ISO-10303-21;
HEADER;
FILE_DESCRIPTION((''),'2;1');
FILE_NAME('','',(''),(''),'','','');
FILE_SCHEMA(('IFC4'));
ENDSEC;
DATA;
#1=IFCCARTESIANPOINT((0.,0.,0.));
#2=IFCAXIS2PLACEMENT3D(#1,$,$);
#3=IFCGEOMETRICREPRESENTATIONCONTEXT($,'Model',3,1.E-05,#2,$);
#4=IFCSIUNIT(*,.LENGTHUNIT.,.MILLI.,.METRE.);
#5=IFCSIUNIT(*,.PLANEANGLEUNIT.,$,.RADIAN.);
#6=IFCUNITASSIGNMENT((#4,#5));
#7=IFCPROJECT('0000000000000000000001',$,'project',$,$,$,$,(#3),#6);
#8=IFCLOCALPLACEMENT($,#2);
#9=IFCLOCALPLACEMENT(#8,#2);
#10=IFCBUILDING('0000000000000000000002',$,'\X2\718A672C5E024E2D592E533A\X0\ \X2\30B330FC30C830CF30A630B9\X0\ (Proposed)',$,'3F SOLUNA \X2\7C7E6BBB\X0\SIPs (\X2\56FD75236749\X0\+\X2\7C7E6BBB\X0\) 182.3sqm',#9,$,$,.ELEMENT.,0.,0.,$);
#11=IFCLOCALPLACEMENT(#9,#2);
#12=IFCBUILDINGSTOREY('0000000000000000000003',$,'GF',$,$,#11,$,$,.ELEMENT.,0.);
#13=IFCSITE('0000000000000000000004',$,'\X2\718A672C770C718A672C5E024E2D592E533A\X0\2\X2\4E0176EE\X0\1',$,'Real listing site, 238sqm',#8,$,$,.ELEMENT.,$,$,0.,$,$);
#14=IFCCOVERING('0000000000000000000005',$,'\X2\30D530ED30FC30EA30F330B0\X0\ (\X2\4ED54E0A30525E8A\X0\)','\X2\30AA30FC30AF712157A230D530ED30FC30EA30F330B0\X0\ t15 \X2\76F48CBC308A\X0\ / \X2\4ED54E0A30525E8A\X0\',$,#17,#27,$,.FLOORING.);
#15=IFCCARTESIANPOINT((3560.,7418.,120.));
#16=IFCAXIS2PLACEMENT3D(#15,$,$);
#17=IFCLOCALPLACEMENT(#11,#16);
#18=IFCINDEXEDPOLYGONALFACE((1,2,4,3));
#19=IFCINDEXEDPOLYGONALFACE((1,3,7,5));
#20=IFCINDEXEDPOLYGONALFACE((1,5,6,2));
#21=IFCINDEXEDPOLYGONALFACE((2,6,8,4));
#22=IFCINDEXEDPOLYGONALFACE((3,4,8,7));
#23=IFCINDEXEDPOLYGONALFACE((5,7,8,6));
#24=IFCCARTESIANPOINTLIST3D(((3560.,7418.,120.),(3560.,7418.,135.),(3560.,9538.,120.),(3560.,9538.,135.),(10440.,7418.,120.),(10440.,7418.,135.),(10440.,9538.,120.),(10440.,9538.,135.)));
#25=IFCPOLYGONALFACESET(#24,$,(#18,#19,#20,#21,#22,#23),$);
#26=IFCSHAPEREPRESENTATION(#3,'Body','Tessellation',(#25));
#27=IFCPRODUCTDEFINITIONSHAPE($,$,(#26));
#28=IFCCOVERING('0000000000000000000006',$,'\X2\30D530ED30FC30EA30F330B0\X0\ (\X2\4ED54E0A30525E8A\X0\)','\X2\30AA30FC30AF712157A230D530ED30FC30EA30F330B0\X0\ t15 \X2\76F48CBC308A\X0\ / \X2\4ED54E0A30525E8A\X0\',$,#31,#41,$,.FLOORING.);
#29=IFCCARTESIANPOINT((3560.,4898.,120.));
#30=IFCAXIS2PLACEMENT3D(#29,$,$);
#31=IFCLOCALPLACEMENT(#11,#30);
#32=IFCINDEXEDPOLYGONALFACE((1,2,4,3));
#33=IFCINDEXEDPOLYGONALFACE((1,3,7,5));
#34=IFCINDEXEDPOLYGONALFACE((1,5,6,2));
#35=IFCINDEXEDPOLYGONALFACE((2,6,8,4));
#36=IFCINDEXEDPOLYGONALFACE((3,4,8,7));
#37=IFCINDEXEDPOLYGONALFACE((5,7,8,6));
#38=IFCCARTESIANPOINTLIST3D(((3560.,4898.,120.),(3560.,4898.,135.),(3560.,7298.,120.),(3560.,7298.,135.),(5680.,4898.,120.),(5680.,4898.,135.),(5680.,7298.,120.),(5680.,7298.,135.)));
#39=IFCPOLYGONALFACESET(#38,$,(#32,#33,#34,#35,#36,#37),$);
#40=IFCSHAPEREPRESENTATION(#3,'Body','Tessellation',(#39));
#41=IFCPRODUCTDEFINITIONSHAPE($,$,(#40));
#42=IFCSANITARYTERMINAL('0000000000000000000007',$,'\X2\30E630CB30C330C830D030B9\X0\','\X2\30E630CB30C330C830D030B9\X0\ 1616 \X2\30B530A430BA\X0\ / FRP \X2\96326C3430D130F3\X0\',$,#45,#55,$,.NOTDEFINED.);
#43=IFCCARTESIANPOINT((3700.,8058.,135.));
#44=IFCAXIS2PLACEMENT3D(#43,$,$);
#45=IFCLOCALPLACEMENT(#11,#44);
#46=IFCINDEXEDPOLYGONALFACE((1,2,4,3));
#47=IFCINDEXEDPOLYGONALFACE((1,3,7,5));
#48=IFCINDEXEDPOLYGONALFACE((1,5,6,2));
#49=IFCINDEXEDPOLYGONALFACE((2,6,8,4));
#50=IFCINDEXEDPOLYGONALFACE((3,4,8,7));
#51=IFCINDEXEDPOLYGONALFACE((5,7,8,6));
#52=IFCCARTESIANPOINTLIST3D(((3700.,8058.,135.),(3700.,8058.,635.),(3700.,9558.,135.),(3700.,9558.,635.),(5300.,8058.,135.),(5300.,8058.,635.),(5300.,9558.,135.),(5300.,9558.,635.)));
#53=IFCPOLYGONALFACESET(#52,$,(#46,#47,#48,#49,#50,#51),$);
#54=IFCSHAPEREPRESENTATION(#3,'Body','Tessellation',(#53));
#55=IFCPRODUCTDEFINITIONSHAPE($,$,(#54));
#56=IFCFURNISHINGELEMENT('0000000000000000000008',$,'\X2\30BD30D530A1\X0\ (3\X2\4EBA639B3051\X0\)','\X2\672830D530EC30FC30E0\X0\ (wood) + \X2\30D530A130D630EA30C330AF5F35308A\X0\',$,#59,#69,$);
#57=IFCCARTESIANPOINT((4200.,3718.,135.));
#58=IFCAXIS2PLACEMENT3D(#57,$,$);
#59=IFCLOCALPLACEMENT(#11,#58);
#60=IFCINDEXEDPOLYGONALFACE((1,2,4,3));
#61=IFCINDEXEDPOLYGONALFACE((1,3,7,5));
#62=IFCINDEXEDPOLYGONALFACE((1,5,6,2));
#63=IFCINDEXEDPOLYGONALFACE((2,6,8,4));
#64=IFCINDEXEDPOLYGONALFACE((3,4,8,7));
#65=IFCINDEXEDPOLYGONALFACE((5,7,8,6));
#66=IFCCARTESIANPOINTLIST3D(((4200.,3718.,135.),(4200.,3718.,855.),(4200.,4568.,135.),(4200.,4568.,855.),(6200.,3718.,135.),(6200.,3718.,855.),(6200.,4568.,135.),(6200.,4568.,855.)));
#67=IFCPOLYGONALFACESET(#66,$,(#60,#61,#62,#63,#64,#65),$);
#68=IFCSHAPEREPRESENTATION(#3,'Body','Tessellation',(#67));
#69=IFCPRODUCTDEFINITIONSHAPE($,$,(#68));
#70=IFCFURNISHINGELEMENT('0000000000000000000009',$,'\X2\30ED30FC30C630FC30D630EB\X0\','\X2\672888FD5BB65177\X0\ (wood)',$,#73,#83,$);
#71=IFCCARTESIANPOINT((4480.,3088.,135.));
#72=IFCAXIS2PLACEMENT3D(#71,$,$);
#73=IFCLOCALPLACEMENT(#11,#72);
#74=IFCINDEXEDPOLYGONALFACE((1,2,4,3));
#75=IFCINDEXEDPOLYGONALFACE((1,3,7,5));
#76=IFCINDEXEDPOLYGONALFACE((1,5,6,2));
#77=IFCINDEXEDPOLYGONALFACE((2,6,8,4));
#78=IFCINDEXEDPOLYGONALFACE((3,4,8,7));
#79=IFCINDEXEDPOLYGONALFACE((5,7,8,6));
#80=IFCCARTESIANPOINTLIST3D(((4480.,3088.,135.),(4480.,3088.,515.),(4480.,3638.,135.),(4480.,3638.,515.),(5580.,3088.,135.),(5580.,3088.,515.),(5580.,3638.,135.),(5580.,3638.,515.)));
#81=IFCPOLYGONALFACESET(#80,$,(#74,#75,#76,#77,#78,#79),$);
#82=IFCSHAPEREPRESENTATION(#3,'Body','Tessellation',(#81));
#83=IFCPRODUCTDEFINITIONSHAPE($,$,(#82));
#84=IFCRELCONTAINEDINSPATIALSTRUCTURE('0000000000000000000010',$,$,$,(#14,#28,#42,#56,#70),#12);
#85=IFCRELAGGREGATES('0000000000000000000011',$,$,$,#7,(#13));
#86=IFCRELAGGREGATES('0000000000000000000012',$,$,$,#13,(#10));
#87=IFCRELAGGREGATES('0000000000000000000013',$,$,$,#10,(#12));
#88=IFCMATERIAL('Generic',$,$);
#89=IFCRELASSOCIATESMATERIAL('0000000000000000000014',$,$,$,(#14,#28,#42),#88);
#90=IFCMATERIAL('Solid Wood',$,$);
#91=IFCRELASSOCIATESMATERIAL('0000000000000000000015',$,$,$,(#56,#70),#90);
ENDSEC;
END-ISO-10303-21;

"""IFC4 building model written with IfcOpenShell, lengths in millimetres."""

from ifc_helpers import new_model, si_unit, frame, frame_2d, origin, place, context, project, spatial, rectangle, extrude, material, element, save


model = new_model("IFC4")

# Units and contexts
model_context = context("Model", 3, precision=1e-05, world=origin())
ifc_project = project(units=[si_unit("LENGTHUNIT", "METRE", prefix="MILLI"), si_unit("PLANEANGLEUNIT", "RADIAN")], contexts=[model_context])

# Site, building, storey
site_placement = place(None, origin())
site = spatial("IfcSite", under=ifc_project, at=site_placement, Name="熊本県熊本市中央区2丁目1", ObjectType="Real listing site, 238sqm", CompositionType="ELEMENT", RefElevation=0.0)
building_placement = place(site_placement, origin())
building = spatial("IfcBuilding", under=site, at=building_placement, Name="熊本市中央区 コートハウス (Proposed)", ObjectType="3F SOLUNA 籾殻SIPs (国産杉+籾殻) 182.3sqm", CompositionType="ELEMENT", ElevationOfRefHeight=0.0, ElevationOfTerrain=0.0)
storey_placement = place(building_placement, origin())
storey = spatial("IfcBuildingStorey", under=building, at=storey_placement, Name="GF", CompositionType="ELEMENT", Elevation=0.0)

# Shared definitions
ifc_material_1 = material(Name="Solid Wood")

# Coverings
ifc_material_2 = material(Name="Generic")
covering_1_placement = place(storey_placement, frame((3560.0, 7418.0, 120.0)))
element("IfcCovering", 1, at=covering_1_placement, inside=storey, material=ifc_material_2, Name="フローリング (仕上げ床)", Description="オーク無垢フローリング t15 直貼り / 仕上げ床", PredefinedType="FLOORING", context=model_context, shape_type="SweptSolid", body=[
    extrude(rectangle(XDim=6880.0, YDim=2120.0, at=frame_2d((3440.0, 1060.0))), frame((3560.0, 7418.0, 120.0)), (0.0, 0.0, 1.0), 15.0),
])
covering_2_placement = place(storey_placement, frame((3560.0, 4898.0, 120.0)))
element("IfcCovering", 2, at=covering_2_placement, inside=storey, material=ifc_material_2, Name="フローリング (仕上げ床)", Description="オーク無垢フローリング t15 直貼り / 仕上げ床", PredefinedType="FLOORING", context=model_context, shape_type="SweptSolid", body=[
    extrude(rectangle(XDim=2120.0, YDim=2400.0, at=frame_2d((1060.0, 1200.0))), frame((3560.0, 4898.0, 120.0)), (0.0, 0.0, 1.0), 15.0),
])

# Sanitary terminal
sanitary_terminal_placement = place(storey_placement, frame((3700.0, 8058.0, 135.0)))
element("IfcSanitaryTerminal", 3, at=sanitary_terminal_placement, inside=storey, material=ifc_material_2, Name="ユニットバス", Description="ユニットバス 1616 サイズ / FRP 防水パン", PredefinedType="NOTDEFINED", context=model_context, shape_type="SweptSolid", body=[
    extrude(rectangle(XDim=1600.0, YDim=1500.0, at=frame_2d((800.0, 750.0))), frame((3700.0, 8058.0, 135.0)), (0.0, 0.0, 1.0), 500.0),
])

# Furnishing elements
furnishing_1_placement = place(storey_placement, frame((4200.0, 3718.0, 135.0)))
element("IfcFurnishingElement", 4, at=furnishing_1_placement, inside=storey, material=ifc_material_1, Name="ソファ (3人掛け)", Description="木フレーム (wood) + ファブリック張り", context=model_context, shape_type="SweptSolid", body=[
    extrude(rectangle(XDim=2000.0, YDim=850.0, at=frame_2d((1000.0, 425.0))), frame((4200.0, 3718.0, 135.0)), (0.0, 0.0, 1.0), 720.0),
])
furnishing_2_placement = place(storey_placement, frame((4480.0, 3088.0, 135.0)))
element("IfcFurnishingElement", 5, at=furnishing_2_placement, inside=storey, material=ifc_material_1, Name="ローテーブル", Description="木製家具 (wood)", context=model_context, shape_type="SweptSolid", body=[
    extrude(rectangle(XDim=1100.0, YDim=550.0, at=frame_2d((550.0, 275.0))), frame((4480.0, 3088.0, 135.0)), (0.0, 0.0, 1.0), 380.0),
])

save(model, "model.ifc")
